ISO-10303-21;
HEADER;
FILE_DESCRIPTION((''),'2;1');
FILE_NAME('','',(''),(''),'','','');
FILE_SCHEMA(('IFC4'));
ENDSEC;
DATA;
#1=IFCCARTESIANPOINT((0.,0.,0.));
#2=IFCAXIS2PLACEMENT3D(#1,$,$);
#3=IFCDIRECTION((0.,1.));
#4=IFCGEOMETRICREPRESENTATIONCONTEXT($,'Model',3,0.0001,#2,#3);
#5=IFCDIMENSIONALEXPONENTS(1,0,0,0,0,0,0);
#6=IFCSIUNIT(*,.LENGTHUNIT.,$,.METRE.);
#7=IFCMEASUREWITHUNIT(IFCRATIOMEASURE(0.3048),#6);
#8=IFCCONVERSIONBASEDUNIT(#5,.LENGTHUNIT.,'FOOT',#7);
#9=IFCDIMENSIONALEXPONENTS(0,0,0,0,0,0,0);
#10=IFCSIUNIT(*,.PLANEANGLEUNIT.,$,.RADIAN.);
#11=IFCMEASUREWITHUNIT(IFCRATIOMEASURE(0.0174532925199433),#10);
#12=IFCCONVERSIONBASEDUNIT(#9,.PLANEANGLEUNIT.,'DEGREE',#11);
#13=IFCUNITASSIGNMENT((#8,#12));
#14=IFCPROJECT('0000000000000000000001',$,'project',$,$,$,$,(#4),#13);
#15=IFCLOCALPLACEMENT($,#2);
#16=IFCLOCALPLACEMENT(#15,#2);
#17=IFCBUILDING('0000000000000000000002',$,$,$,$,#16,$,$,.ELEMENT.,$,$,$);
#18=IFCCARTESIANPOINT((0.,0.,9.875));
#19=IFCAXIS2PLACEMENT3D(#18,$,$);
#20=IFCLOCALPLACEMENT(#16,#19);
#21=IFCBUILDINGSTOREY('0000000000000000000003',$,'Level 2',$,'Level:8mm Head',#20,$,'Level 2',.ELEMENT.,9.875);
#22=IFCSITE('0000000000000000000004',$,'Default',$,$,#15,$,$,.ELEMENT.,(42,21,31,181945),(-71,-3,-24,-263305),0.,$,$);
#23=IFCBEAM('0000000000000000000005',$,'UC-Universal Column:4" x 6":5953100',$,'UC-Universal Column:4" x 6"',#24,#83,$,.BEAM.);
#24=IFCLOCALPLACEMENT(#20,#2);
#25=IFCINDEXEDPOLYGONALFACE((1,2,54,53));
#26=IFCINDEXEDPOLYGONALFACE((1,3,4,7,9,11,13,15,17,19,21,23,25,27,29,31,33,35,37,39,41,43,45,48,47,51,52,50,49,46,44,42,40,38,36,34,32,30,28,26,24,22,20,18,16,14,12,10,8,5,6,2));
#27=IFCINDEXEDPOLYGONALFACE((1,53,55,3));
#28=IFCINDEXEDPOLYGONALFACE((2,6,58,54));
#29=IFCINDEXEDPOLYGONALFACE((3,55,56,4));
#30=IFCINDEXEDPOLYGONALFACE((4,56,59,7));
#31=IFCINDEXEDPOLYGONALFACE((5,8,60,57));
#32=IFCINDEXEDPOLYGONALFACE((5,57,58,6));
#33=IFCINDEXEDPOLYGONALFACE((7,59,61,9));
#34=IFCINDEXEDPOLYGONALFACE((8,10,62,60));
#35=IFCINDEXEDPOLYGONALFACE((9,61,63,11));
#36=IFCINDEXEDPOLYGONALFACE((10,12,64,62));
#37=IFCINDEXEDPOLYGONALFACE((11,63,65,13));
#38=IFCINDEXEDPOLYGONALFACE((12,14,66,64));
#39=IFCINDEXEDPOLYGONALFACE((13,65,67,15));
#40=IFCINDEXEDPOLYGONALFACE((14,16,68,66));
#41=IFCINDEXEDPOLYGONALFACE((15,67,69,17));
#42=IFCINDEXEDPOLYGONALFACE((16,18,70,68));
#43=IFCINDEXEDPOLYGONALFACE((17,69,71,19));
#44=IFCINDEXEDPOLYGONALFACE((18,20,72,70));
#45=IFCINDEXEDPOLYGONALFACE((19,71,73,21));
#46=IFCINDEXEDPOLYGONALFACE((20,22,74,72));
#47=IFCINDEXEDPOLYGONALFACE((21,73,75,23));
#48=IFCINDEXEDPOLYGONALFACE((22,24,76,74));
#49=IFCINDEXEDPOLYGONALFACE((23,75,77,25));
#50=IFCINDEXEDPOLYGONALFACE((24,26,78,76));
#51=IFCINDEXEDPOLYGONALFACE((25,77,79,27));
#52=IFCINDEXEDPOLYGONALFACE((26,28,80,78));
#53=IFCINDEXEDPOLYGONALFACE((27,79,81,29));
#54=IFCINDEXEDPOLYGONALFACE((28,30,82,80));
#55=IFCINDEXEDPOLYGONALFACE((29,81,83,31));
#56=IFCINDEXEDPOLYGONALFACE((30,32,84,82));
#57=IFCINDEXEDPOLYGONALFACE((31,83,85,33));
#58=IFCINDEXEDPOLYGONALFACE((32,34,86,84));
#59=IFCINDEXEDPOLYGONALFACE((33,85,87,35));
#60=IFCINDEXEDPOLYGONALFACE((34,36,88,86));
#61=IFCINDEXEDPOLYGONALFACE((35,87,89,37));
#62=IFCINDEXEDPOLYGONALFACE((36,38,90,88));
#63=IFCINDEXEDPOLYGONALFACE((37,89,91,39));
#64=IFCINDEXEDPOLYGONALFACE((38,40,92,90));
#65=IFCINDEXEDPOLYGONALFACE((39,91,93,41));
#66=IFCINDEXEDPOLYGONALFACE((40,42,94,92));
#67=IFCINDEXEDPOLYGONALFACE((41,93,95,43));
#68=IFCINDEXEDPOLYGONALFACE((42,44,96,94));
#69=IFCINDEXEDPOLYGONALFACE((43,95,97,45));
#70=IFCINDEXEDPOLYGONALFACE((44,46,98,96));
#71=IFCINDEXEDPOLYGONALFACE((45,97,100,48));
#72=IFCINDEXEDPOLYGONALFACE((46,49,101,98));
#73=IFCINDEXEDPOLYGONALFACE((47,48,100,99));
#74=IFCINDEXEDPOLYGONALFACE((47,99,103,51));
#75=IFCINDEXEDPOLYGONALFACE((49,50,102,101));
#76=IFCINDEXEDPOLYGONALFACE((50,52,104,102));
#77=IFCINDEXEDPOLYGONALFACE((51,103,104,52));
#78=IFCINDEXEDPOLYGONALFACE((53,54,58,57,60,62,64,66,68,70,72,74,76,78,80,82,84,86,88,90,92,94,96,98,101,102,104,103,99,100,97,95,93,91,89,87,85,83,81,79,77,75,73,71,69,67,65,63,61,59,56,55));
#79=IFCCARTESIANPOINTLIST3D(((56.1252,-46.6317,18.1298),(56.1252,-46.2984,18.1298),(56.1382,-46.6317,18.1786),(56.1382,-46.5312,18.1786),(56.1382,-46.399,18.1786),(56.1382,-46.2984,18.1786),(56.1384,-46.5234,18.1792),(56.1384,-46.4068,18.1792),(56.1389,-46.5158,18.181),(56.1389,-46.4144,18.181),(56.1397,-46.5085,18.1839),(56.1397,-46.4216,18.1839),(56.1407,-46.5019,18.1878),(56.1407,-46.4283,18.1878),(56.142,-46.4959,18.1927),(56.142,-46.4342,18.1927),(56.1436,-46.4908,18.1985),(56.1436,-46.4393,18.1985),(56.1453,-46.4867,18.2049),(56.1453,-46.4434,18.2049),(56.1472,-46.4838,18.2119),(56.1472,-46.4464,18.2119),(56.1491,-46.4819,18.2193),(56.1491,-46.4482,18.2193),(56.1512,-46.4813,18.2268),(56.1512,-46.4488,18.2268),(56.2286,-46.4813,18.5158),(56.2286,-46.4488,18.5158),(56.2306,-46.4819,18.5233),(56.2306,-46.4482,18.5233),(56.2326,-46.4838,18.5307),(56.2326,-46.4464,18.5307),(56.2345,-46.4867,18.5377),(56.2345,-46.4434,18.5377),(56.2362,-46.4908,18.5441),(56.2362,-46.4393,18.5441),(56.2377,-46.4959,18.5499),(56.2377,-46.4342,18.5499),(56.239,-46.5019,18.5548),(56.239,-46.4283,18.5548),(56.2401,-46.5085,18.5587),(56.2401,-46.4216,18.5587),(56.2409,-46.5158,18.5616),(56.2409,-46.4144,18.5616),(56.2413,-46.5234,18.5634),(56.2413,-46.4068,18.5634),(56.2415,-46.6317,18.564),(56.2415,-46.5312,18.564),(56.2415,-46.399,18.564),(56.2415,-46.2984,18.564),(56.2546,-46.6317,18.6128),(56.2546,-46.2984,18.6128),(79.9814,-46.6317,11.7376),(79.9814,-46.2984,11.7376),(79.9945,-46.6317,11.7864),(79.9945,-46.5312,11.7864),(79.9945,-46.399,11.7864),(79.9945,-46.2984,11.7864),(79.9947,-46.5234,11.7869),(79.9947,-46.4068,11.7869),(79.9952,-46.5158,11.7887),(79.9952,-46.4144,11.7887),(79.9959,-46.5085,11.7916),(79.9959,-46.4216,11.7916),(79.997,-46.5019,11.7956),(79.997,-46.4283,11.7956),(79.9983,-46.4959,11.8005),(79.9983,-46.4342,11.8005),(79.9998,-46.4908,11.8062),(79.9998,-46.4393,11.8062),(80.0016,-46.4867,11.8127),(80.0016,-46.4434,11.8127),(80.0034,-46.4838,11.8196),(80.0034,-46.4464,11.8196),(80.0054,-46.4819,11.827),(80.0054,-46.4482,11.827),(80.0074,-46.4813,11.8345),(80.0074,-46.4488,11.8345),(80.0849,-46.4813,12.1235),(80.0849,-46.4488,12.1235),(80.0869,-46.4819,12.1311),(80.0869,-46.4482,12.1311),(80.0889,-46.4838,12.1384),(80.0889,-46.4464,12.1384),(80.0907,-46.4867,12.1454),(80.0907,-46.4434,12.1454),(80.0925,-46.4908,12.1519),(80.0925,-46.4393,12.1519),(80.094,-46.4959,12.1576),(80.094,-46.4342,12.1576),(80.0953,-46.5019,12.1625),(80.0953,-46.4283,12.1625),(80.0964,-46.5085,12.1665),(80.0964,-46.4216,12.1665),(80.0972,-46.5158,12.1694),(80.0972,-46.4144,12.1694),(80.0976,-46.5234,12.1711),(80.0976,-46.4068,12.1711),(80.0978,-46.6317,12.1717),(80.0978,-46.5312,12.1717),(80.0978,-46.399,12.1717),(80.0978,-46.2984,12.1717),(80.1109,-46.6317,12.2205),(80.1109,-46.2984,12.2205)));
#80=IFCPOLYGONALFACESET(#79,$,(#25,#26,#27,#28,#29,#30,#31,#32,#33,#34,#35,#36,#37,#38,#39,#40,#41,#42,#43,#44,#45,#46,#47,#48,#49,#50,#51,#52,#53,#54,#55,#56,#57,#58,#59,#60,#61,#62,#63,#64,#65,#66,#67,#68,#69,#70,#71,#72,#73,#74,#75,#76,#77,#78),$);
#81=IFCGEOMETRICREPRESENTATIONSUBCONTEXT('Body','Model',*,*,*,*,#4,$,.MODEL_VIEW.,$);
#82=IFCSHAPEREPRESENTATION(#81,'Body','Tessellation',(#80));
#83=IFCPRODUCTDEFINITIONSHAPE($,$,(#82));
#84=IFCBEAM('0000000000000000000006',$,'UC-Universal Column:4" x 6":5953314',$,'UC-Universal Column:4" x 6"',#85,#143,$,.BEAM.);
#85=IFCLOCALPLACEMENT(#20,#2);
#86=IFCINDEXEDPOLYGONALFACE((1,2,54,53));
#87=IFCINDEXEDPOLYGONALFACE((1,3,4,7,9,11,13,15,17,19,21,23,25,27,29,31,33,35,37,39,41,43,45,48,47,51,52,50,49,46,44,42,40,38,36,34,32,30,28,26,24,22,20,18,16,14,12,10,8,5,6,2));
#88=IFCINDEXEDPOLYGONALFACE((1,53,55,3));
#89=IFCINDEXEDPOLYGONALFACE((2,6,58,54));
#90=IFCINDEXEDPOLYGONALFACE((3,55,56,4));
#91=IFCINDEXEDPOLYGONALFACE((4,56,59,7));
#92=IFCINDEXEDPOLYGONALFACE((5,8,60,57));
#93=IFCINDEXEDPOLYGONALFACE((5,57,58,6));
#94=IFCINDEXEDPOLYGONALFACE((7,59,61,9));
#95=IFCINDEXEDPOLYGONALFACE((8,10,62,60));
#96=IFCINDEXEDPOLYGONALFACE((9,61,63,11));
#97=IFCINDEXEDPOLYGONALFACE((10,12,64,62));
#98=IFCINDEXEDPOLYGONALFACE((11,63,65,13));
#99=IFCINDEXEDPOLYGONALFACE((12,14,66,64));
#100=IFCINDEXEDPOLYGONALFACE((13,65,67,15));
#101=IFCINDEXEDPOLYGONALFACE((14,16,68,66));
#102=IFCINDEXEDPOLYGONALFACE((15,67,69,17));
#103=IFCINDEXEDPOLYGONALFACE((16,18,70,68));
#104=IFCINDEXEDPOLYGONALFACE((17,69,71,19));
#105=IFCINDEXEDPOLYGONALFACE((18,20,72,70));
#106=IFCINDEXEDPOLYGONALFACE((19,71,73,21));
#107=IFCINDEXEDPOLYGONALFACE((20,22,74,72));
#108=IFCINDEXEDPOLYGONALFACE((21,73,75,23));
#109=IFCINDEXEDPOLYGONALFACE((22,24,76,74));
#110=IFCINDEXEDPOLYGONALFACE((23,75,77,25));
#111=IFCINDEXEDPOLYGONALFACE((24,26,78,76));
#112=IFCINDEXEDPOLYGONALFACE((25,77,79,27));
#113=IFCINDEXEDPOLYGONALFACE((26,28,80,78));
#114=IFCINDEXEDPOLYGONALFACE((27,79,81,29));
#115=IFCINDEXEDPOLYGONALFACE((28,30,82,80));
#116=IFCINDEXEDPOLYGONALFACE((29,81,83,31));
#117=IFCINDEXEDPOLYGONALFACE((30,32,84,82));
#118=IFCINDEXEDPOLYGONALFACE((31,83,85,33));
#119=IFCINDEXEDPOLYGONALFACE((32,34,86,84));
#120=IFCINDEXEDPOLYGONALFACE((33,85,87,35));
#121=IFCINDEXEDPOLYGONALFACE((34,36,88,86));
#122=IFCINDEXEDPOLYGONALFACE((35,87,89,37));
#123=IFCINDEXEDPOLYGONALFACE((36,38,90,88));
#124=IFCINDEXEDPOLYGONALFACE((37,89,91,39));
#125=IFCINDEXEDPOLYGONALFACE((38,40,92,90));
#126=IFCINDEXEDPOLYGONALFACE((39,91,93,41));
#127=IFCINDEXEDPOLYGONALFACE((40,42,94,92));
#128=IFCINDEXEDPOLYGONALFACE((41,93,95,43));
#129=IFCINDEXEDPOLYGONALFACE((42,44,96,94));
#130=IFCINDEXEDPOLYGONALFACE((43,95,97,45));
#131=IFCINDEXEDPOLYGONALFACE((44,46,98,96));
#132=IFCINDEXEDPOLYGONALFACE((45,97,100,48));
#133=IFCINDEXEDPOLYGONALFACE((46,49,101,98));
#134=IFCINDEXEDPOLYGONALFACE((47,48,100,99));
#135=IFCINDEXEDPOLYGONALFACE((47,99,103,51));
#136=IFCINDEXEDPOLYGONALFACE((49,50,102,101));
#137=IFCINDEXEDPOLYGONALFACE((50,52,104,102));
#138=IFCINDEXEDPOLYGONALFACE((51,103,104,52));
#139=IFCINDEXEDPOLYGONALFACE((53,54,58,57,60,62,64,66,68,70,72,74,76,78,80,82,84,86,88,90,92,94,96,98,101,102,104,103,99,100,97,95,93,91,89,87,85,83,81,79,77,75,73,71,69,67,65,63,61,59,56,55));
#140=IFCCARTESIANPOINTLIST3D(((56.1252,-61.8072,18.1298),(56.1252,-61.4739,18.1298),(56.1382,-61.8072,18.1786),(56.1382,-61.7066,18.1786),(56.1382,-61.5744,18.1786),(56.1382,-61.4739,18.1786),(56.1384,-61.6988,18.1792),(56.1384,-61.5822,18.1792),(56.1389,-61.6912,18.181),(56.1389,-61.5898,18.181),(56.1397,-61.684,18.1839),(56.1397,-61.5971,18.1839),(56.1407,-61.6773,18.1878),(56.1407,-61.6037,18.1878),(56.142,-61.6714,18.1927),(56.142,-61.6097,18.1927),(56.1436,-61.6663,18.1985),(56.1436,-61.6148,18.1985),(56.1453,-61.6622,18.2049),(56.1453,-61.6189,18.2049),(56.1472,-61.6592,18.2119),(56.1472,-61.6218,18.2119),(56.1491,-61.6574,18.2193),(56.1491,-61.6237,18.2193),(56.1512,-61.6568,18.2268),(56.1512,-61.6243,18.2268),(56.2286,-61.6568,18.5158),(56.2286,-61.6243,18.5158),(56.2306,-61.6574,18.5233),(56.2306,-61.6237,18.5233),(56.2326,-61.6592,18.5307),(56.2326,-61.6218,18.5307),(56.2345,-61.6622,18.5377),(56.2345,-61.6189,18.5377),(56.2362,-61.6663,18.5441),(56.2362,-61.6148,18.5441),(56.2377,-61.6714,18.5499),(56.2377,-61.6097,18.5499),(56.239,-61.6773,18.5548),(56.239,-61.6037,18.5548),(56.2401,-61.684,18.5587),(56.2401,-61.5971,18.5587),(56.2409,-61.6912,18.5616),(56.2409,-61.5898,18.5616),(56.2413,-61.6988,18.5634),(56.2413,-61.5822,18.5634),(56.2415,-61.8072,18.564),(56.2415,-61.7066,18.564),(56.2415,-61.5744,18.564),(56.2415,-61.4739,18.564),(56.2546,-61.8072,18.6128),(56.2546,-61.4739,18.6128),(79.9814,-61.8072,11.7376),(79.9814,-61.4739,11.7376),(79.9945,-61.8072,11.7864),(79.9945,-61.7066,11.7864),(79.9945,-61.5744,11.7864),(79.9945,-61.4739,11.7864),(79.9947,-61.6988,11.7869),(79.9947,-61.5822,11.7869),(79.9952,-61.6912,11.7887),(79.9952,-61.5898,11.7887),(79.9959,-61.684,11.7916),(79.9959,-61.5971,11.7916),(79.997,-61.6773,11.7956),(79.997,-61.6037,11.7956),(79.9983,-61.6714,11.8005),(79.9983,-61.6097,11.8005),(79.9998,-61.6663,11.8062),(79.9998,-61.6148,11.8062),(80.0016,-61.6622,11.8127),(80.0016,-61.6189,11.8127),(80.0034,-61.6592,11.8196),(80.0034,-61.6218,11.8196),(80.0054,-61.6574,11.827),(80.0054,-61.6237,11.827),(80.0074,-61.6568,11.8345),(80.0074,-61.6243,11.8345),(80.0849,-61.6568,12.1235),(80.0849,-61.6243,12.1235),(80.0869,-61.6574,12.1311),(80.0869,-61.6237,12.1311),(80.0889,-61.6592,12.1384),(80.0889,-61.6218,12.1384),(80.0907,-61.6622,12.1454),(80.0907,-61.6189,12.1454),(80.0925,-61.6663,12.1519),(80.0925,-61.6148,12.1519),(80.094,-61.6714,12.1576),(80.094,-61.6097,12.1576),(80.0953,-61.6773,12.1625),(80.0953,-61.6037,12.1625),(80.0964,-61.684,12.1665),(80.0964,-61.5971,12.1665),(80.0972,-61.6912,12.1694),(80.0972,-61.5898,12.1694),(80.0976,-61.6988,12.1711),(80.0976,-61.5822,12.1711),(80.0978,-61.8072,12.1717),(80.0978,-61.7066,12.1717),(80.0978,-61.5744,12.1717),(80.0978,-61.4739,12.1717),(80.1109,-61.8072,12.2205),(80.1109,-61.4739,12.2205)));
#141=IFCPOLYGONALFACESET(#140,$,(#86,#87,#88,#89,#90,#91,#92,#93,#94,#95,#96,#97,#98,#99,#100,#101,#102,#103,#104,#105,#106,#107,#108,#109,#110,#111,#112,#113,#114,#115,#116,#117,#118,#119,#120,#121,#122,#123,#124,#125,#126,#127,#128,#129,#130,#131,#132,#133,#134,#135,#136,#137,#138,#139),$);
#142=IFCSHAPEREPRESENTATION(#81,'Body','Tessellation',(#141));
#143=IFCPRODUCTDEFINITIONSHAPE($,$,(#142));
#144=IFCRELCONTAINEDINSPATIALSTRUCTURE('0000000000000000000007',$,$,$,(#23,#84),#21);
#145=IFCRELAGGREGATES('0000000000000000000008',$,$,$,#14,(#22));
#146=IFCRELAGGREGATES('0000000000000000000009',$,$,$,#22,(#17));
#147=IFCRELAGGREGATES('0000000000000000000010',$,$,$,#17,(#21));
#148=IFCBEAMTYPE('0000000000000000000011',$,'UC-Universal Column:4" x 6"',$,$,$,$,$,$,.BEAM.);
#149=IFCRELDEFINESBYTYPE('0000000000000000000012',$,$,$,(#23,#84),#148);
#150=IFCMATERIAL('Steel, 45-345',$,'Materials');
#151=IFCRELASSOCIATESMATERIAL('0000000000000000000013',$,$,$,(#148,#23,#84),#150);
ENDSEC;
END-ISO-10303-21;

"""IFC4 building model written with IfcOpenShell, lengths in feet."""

from ifc_helpers import new_model, entity, si_unit, converted_unit, direction, frame, origin, place, context, subcontext, project, spatial, indexed_curve, outline, extrude, source, transform, mapped, material, type_object, type_shapes, element, save


model = new_model("IFC4")

# Units and contexts
model_context = context("Model", 3, precision=0.0001, world=origin(), true_north=direction((0.0, 1.0)))
body_context = subcontext(model_context, "Body", "Model", "MODEL_VIEW")
ifc_project = project(units=[converted_unit("LENGTHUNIT", "FOOT", entity("IfcRatioMeasure", 0.3048), si_unit("LENGTHUNIT", "METRE"), dimensions=[1, 0, 0, 0, 0, 0, 0]), converted_unit("PLANEANGLEUNIT", "DEGREE", entity("IfcRatioMeasure", 0.0174532925199433), si_unit("PLANEANGLEUNIT", "RADIAN"), dimensions=[0, 0, 0, 0, 0, 0, 0])], contexts=[model_context])

# Site, building, storey
site_placement = place(None, origin())
site = spatial("IfcSite", under=ifc_project, at=site_placement, Name="Default", CompositionType="ELEMENT", RefLatitude=(42, 21, 31, 181945), RefLongitude=(-71, -3, -24, -263305), RefElevation=0.0)
building_placement = place(site_placement, origin())
building = spatial("IfcBuilding", under=site, at=building_placement, CompositionType="ELEMENT")
storey_placement = place(building_placement, frame((0.0, 0.0, 9.875)))
storey = spatial("IfcBuildingStorey", under=building, at=storey_placement, Name="Level 2", ObjectType="Level:8mm Head", LongName="Level 2", CompositionType="ELEMENT", Elevation=9.875)

# Beams
ifc_material_1 = material(Name="Steel, 45-345", Category="Materials")
beam_type_1 = type_object("IfcBeamType", Name="UC-Universal Column:4\" x 6\"", PredefinedType="BEAM", material=ifc_material_1)
shared_shape_1 = source(origin(), body_context, "Body", "SweptSolid", [
    extrude(outline(indexed_curve([(-0.25, -0.1667), (-0.1995, -0.1667), (-0.1995, -0.0661), (-0.1989, -0.0583), (-0.197, -0.0507), (-0.194, -0.0435), (-0.19, -0.0368), (-0.1849, -0.0308), (-0.1789, -0.0258), (-0.1722, -0.0217), (-0.165, -0.0187), (-0.1574, -0.0169), (-0.1496, -0.0162), (0.1496, -0.0162), (0.1574, -0.0169), (0.165, -0.0187), (0.1722, -0.0217), (0.1789, -0.0258), (0.1849, -0.0308), (0.19, -0.0368), (0.194, -0.0435), (0.197, -0.0507), (0.1989, -0.0583), (0.1995, -0.0661), (0.1995, -0.1667), (0.25, -0.1667), (0.25, 0.1667), (0.1995, 0.1667), (0.1995, 0.0661), (0.1989, 0.0583), (0.197, 0.0507), (0.194, 0.0435), (0.19, 0.0368), (0.1849, 0.0308), (0.1789, 0.0258), (0.1722, 0.0217), (0.165, 0.0187), (0.1574, 0.0169), (0.1496, 0.0162), (-0.1496, 0.0162), (-0.1574, 0.0169), (-0.165, 0.0187), (-0.1722, 0.0217), (-0.1789, 0.0258), (-0.1849, 0.0308), (-0.19, 0.0368), (-0.194, 0.0435), (-0.197, 0.0507), (-0.1989, 0.0583), (-0.1995, 0.0661), (-0.1995, 0.1667), (-0.25, 0.1667), (-0.25, -0.1667)], self_intersect=False)), frame((-12.1817, 0.0, 0.0), z_axis=(1.0, 0.0, 0.0), x_axis=(0.0, 0.0, -1.0)), (0.0, 0.0, 1.0), 24.6978),
])
type_shapes(beam_type_1, [shared_shape_1])
for number, where, z_axis, x_axis, name in (
    (1, (67.9565, -46.4651, 15.2185), (0.258819, 0.0, 0.965926), (0.965926, 0.0, -0.258819), "UC-Universal Column:4\" x 6\":5953100"),
    (2, (67.9565, -61.6405, 15.2185), (0.258819, 0.0, 0.965926), (0.965926, 0.0, -0.258819), "UC-Universal Column:4\" x 6\":5953314"),
):
    element("IfcBeam", number, at=place(storey_placement, frame(where, z_axis=z_axis, x_axis=x_axis)), inside=storey, type_object=beam_type_1, material=ifc_material_1, Name=name, ObjectType="UC-Universal Column:4\" x 6\"", PredefinedType="BEAM", context=body_context, shape_type="MappedRepresentation", body=[
        mapped(shared_shape_1, transform((0.0, 0.0, 0.0), scale=1.0)),
    ])

save(model, "model.ifc")
